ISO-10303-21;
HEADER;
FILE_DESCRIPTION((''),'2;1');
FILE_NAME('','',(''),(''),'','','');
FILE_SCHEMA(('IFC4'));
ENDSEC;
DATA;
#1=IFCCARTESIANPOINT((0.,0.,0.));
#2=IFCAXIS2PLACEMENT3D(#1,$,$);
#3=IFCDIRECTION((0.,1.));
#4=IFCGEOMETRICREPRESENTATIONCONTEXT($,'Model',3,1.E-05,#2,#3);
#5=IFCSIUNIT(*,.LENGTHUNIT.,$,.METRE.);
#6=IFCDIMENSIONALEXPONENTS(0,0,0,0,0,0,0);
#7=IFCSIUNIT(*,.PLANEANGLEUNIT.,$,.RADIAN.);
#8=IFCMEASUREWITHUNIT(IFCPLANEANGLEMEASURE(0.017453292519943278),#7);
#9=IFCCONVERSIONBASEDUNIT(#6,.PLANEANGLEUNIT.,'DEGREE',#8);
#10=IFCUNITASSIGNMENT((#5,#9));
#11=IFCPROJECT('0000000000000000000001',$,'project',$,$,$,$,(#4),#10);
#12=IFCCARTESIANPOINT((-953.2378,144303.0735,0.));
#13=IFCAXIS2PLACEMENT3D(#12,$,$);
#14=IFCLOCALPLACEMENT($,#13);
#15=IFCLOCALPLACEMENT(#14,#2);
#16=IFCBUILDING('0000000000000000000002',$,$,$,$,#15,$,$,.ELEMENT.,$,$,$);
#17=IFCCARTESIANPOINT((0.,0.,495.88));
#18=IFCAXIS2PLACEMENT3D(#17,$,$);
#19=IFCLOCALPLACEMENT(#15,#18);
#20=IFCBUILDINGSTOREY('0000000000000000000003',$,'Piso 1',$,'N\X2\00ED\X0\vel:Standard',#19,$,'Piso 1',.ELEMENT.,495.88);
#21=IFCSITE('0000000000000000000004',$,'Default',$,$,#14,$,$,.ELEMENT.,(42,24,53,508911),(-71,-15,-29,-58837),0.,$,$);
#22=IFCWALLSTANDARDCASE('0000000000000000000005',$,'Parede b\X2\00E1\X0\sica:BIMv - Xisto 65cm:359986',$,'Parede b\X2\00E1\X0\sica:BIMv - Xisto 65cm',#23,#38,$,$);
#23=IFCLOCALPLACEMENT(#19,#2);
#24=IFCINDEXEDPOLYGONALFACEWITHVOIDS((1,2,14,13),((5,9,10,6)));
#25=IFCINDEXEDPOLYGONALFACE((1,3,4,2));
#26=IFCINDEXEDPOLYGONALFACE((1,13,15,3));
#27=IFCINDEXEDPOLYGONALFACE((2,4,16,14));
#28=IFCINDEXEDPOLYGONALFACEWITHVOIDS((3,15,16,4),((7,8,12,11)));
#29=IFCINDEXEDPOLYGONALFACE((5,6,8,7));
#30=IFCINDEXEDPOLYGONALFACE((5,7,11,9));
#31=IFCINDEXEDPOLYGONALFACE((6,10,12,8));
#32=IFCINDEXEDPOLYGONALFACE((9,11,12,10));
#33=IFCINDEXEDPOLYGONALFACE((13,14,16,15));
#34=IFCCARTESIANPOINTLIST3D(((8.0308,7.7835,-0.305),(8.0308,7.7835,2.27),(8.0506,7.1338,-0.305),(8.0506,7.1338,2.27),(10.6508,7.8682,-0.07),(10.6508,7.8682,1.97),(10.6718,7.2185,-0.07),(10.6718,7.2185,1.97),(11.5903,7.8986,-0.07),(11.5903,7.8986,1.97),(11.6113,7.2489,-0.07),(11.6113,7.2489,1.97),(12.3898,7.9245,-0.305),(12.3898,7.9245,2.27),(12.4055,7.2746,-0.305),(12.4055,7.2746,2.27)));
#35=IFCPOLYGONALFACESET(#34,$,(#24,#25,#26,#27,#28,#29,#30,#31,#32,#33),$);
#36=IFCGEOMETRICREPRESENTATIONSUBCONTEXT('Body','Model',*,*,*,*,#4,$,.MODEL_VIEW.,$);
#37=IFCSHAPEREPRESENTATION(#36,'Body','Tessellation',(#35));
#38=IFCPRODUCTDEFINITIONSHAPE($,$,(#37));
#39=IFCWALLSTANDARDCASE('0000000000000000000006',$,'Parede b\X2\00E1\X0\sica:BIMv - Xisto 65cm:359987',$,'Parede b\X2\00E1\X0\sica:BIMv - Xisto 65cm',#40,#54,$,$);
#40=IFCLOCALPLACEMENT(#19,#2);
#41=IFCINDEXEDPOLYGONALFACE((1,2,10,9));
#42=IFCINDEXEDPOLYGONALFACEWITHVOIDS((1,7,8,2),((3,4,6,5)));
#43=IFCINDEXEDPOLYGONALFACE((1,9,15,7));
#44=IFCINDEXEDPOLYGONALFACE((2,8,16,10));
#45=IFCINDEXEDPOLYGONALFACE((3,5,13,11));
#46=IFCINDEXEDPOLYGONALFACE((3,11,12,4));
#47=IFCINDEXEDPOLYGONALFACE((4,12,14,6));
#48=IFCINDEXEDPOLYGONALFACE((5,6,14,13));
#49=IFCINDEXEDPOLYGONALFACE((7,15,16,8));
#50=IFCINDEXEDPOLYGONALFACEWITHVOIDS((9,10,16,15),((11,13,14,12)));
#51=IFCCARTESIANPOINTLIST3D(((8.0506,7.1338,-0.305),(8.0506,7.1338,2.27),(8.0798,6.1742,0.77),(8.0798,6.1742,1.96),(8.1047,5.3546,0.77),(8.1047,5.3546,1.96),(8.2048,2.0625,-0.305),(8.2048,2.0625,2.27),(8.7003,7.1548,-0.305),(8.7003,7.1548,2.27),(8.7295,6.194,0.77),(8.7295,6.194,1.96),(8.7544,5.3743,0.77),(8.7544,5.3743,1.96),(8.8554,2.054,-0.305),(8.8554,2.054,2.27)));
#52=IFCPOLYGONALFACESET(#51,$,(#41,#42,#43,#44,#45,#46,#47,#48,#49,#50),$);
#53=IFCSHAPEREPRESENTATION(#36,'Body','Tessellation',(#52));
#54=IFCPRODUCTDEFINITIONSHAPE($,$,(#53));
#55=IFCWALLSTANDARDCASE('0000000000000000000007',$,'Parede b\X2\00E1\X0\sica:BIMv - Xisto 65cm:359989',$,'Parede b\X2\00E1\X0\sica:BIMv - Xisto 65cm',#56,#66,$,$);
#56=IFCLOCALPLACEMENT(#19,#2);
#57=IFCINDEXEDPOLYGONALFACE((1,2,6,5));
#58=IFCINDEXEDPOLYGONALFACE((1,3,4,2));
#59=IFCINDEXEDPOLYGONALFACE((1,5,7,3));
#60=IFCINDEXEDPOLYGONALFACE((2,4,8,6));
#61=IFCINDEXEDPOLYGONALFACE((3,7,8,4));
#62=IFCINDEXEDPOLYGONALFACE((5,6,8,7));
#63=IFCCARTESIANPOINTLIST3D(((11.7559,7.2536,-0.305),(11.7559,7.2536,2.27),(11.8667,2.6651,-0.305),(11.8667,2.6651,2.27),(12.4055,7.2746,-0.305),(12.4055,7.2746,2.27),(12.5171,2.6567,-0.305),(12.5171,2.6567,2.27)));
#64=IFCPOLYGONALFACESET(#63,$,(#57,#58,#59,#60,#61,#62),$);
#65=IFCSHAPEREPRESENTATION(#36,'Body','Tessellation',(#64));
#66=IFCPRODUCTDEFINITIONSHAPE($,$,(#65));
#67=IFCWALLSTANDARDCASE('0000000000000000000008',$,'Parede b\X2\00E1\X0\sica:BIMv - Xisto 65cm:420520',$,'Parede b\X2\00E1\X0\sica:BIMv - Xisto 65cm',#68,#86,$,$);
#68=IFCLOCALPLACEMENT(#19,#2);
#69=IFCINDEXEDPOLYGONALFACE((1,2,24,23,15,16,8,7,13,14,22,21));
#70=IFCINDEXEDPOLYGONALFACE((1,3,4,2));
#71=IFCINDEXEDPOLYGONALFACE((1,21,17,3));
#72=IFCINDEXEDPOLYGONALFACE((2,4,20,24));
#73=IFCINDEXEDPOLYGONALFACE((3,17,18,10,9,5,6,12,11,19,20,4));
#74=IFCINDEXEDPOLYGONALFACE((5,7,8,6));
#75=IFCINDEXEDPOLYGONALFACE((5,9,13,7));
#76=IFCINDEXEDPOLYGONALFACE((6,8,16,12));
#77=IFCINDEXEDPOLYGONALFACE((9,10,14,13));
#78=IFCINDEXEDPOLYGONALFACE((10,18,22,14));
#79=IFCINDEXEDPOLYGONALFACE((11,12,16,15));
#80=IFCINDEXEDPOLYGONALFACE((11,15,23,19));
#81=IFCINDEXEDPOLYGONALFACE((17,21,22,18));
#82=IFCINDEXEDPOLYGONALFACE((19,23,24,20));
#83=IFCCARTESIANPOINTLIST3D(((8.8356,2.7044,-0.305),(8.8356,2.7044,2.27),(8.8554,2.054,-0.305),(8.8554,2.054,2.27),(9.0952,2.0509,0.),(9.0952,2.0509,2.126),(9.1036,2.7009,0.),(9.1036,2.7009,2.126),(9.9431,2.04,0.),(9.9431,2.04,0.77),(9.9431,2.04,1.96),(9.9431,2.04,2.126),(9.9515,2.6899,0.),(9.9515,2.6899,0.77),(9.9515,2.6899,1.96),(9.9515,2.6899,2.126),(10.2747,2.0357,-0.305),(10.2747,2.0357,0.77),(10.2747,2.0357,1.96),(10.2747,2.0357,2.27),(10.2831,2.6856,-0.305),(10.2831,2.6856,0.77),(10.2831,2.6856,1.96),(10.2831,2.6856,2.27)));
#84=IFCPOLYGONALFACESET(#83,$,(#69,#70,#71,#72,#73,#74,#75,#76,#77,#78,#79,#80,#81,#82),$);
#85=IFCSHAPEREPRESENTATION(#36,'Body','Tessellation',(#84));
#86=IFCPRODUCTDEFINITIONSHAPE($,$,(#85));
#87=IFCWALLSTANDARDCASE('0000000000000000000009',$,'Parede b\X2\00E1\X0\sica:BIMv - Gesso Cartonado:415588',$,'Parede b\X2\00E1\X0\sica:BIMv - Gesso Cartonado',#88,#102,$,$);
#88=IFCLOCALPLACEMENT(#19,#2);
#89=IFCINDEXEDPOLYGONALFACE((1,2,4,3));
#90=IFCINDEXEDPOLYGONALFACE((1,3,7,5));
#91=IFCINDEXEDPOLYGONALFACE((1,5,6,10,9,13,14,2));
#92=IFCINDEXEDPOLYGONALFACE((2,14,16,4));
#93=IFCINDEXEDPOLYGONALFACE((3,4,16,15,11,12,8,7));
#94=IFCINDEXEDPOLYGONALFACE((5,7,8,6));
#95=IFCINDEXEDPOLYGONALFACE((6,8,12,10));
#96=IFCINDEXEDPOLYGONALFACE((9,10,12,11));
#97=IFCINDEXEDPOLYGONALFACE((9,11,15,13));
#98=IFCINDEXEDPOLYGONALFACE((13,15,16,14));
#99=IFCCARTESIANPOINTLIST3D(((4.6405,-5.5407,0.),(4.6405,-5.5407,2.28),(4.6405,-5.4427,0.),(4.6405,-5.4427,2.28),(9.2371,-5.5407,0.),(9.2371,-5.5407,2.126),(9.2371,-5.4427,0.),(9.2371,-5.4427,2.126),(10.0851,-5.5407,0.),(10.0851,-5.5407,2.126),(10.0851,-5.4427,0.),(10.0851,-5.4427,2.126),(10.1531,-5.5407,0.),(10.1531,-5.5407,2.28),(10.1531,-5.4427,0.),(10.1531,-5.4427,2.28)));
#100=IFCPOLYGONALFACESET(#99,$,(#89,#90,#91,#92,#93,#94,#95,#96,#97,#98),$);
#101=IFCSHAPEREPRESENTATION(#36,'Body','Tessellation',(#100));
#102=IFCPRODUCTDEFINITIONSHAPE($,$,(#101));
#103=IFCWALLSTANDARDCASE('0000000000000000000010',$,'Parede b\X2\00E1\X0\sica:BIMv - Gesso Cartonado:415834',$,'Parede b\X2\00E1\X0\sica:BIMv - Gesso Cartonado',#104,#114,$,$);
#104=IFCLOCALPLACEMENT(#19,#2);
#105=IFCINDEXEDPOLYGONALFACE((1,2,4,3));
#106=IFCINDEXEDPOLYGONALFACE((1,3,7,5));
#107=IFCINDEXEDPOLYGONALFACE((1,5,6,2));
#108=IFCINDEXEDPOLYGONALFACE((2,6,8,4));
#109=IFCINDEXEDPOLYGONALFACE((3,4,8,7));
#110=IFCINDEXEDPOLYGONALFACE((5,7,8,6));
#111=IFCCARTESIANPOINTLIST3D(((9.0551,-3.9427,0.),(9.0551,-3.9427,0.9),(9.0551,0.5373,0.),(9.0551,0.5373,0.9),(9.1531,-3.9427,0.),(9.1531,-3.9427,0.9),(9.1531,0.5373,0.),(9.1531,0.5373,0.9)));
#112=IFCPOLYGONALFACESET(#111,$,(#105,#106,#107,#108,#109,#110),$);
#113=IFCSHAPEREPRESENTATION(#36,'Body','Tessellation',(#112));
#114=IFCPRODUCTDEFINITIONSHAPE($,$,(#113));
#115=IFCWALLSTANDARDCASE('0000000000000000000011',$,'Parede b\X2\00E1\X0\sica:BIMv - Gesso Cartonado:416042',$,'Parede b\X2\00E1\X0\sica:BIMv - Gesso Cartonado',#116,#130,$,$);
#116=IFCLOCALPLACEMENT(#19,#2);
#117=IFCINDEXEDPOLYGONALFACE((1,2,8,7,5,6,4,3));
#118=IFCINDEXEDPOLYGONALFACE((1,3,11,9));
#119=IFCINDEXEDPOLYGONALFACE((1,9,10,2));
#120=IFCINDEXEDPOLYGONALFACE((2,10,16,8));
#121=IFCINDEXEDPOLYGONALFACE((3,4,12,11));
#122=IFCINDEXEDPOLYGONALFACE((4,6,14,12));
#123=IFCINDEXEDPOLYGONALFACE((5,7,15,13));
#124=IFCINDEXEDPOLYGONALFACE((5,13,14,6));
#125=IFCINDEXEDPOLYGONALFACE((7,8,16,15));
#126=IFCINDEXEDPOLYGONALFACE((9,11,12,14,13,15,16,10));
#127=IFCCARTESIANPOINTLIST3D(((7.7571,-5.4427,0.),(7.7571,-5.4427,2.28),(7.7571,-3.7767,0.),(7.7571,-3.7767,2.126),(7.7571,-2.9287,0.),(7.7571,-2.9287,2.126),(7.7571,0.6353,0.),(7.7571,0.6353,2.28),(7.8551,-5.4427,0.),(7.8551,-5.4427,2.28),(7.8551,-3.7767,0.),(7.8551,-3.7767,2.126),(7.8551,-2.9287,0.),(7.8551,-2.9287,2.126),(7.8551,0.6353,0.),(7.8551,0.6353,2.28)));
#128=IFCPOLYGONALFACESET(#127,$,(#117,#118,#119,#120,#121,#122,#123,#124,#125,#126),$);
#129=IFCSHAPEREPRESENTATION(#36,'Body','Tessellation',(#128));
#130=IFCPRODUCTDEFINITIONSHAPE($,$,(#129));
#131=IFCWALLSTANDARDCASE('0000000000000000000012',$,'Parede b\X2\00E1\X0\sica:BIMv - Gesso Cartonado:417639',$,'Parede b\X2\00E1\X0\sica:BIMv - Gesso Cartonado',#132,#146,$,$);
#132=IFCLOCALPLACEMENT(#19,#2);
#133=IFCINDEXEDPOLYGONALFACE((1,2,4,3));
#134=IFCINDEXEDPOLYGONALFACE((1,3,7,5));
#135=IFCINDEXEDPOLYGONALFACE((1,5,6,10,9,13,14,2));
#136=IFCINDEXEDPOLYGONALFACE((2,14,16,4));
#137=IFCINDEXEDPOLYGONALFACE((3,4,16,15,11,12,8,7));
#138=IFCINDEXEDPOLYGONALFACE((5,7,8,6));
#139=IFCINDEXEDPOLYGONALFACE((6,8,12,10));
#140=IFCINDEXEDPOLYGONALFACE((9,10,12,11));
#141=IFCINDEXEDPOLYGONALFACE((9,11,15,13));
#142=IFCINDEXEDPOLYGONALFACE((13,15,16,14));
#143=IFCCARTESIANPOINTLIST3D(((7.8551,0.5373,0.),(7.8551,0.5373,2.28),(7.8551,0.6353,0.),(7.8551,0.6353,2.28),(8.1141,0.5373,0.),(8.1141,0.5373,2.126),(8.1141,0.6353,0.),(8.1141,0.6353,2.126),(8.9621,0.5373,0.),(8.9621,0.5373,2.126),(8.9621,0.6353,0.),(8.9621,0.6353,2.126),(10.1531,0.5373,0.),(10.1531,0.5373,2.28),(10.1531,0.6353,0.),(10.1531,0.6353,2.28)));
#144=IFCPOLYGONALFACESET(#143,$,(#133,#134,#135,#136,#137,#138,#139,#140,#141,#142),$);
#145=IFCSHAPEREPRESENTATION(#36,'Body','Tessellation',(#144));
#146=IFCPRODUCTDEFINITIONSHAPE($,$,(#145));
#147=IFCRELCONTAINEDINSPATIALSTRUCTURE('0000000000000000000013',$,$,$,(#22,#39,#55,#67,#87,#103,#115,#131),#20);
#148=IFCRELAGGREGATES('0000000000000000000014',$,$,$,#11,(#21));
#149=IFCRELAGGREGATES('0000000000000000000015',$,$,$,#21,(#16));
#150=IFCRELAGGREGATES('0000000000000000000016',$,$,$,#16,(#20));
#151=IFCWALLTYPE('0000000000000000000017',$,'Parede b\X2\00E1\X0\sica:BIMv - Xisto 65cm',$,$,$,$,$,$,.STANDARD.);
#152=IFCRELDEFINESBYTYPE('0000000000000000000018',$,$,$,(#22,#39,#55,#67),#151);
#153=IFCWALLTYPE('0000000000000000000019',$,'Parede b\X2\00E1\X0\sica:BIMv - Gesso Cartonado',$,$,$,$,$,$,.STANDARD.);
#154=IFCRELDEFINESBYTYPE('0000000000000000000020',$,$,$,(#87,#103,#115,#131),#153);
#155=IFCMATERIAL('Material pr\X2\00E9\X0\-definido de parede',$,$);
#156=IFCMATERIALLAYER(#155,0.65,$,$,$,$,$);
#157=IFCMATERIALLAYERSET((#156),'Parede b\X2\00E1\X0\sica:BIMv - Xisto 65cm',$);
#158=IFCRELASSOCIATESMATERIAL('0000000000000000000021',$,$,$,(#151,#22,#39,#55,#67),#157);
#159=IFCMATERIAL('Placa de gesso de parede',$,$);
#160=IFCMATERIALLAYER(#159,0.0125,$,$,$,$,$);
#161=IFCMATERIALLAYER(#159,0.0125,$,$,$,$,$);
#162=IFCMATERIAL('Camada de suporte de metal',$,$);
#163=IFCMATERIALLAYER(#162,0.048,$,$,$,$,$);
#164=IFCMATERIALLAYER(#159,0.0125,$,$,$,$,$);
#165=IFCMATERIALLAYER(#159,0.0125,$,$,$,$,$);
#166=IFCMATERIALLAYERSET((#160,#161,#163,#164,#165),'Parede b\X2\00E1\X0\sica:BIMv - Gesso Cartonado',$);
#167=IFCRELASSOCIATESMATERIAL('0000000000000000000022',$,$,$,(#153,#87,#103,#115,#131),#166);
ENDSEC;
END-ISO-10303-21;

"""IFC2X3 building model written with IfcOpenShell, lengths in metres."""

from ifc_helpers import new_model, entity, si_unit, converted_unit, direction, frame, frame_2d, origin, origin_2d_with_axis, place, context, subcontext, project, spatial, polyline, rectangle, outline, extrude, clip, bounded_halfspace, material, layer, layer_set, layer_usage, type_object, element, save


model = new_model("IFC2X3")

# Units and contexts
model_context = context("Model", 3, precision=1e-05, world=origin(), true_north=direction((0.0, 1.0)))
body_context = subcontext(model_context, "Body", "Model", "MODEL_VIEW")
ifc_project = project(units=[si_unit("LENGTHUNIT", "METRE"), converted_unit("PLANEANGLEUNIT", "DEGREE", entity("IfcPlaneAngleMeasure", 0.017453292519943278), si_unit("PLANEANGLEUNIT", "RADIAN"), dimensions=[0, 0, 0, 0, 0, 0, 0])], contexts=[model_context])

# Site, building, storey
site_placement = place(None, frame((-953.2378, 144303.0735, 0.0)))
site = spatial("IfcSite", under=ifc_project, at=site_placement, Name="Default", CompositionType="ELEMENT", RefLatitude=(42, 24, 53, 508911), RefLongitude=(-71, -15, -29, -58837), RefElevation=0.0)
building_placement = place(site_placement, origin())
building = spatial("IfcBuilding", under=site, at=building_placement, CompositionType="ELEMENT")
storey_placement = place(building_placement, frame((0.0, 0.0, 495.88)))
storey = spatial("IfcBuildingStorey", under=building, at=storey_placement, Name="Piso 1", ObjectType="Nível:Standard", LongName="Piso 1", CompositionType="ELEMENT", Elevation=495.88)

# Walls, openings
ifc_material_1 = material(Name="Material pré-definido de parede")
ifc_layer_1 = layer(ifc_material_1, 0.65)
ifc_layer_set_1 = layer_set([ifc_layer_1], Name="Parede básica:BIMv - Xisto 65cm")
ifc_layer_usage_1 = layer_usage(ifc_layer_set_1, "AXIS2", "NEGATIVE", 0.325)
wall_type_1 = type_object("IfcWallType", Name="Parede básica:BIMv - Xisto 65cm", PredefinedType="STANDARD", material=ifc_layer_set_1)
wall_1_placement = place(storey_placement, frame((8.0401, 7.4586, -0.305), z_axis=(0.0, 0.0, 1.0), x_axis=(0.999477, 0.03233, 0.0)))
wall_1 = element("IfcWallStandardCase", 1, at=wall_1_placement, inside=storey, type_object=wall_type_1, material=ifc_layer_usage_1, Name="Parede básica:BIMv - Xisto 65cm:359986", ObjectType="Parede básica:BIMv - Xisto 65cm", context=body_context, shape_type="SweptSolid", body=[
    extrude(outline(polyline([(4.3572, -0.325), (4.3625, 0.325), (0.0013, 0.325), (0.0, -0.325), (0.65, -0.325), (3.7072, -0.325), (4.3572, -0.325)])), origin(), (0.0, 0.0, 1.0), 2.575),
])
opening_1_placement = place(wall_1_placement, frame((-8.277, -7.1948, 0.305), z_axis=(0.0, 0.0, 1.0), x_axis=(0.999477, -0.03233, 0.0)))
element("IfcOpeningElement", 2, at=opening_1_placement, cuts=wall_1, ObjectType="Opening", context=body_context, shape_type="SweptSolid", body=[
    extrude(rectangle(XDim=2.04, YDim=0.94, at=frame_2d((0.0, 0.0), x_axis=(0.0, 1.0))), frame((11.1908, 5.7105, 0.95), z_axis=(-0.03233, 0.999477, 0.0), x_axis=(-0.999477, -0.03233, 0.0)), (0.0, 0.0, 1.0), 3.048),
])
ifc_layer_usage_2 = layer_usage(ifc_layer_set_1, "AXIS2", "NEGATIVE", 0.325)
wall_2_placement = place(storey_placement, frame((8.5305, 2.0442, -0.305), z_axis=(0.0, 0.0, 1.0), x_axis=(-0.030399, 0.999538, 0.0)))
wall_2 = element("IfcWallStandardCase", 3, at=wall_2_placement, inside=storey, type_object=wall_type_1, material=ifc_layer_usage_2, Name="Parede básica:BIMv - Xisto 65cm:359987", ObjectType="Parede básica:BIMv - Xisto 65cm", context=body_context, shape_type="SweptSolid", body=[
    extrude(outline(polyline([(5.1031, -0.325), (5.1018, 0.325), (0.0282, 0.325), (0.0, -0.325), (5.1031, -0.325)])), origin(), (0.0, 0.0, 1.0), 2.575),
])
opening_2_placement = place(wall_2_placement, frame((-1.7839, 8.5887, 0.305), z_axis=(0.0, 0.0, 1.0), x_axis=(-0.030399, -0.999538, 0.0)))
element("IfcOpeningElement", 4, at=opening_2_placement, cuts=wall_2, ObjectType="Opening", context=body_context, shape_type="SweptSolid", body=[
    extrude(rectangle(XDim=1.19, YDim=0.82, at=origin_2d_with_axis()), frame((10.2652, 5.8305, 1.365), z_axis=(-0.999538, -0.030399, 0.0), x_axis=(0.0, 0.0, 1.0)), (0.0, 0.0, 1.0), 3.048),
])

# Wall
ifc_layer_usage_3 = layer_usage(ifc_layer_set_1, "AXIS2", "NEGATIVE", 0.325)
wall_3_placement = place(storey_placement, frame((12.0806, 7.2668, -0.305), z_axis=(0.0, 0.0, 1.0), x_axis=(0.024156, -0.999708, 0.0)))
element("IfcWallStandardCase", 5, at=wall_3_placement, inside=storey, type_object=wall_type_1, material=ifc_layer_usage_3, Name="Parede básica:BIMv - Xisto 65cm:359989", ObjectType="Parede básica:BIMv - Xisto 65cm", context=body_context, shape_type="SweptSolid", body=[
    extrude(outline(polyline([(4.5951, -0.325), (4.6193, 0.325), (0.0, 0.325), (0.0053, -0.325), (4.5951, -0.325)])), origin(), (0.0, 0.0, 1.0), 2.575),
])

# Wall, openings
ifc_layer_usage_4 = layer_usage(ifc_layer_set_1, "AXIS2", "NEGATIVE", 0.325)
wall_4_placement = place(storey_placement, frame((10.2789, 2.3607, -0.305), z_axis=(0.0, 0.0, 1.0), x_axis=(-0.999916, 0.012938, 0.0)))
wall_4 = element("IfcWallStandardCase", 6, at=wall_4_placement, inside=storey, type_object=wall_type_1, material=ifc_layer_usage_4, Name="Parede básica:BIMv - Xisto 65cm:420520", ObjectType="Parede básica:BIMv - Xisto 65cm", context=body_context, shape_type="SweptSolid", body=[
    extrude(outline(polyline([(1.4476, -0.325), (1.4194, 0.325), (0.0, 0.325), (0.0, -0.325), (1.4476, -0.325)])), origin(), (0.0, 0.0, 1.0), 2.575),
])
opening_3_placement = place(wall_4_placement, frame((10.2475, 2.4934, 0.305), z_axis=(0.0, 0.0, 1.0), x_axis=(-0.999916, -0.012938, 0.0)))
element("IfcOpeningElement", 7, at=opening_3_placement, cuts=wall_4, ObjectType="Opening", context=body_context, shape_type="SweptSolid", body=[
    extrude(rectangle(XDim=1.19, YDim=0.9, at=frame_2d((0.0, 0.0), x_axis=(0.0, 1.0))), frame((9.8444, 3.5654, 1.365), z_axis=(-0.012938, -0.999916, 0.0), x_axis=(0.999916, -0.012938, 0.0)), (0.0, 0.0, 1.0), 3.048),
])
opening_4_placement = place(wall_4_placement, frame((1.1796, 0.325, 0.305)))
element("IfcOpeningElement", 8, at=opening_4_placement, cuts=wall_4, ObjectType="Opening", context=body_context, shape_type="SweptSolid", body=[
    extrude(rectangle(XDim=2.126, YDim=0.848, at=frame_2d((1.063, 0.424), x_axis=(1.0, 0.0))), frame((0.0, 0.0, 0.0), z_axis=(0.0, -1.0, 0.0), x_axis=(0.0, 0.0, 1.0)), (0.0, 0.0, 1.0), 0.65),
])

# Wall, opening
ifc_material_2 = material(Name="Placa de gesso de parede")
ifc_layer_2 = layer(ifc_material_2, 0.0125)
ifc_layer_3 = layer(ifc_material_2, 0.0125)
ifc_material_3 = material(Name="Camada de suporte de metal")
ifc_layer_4 = layer(ifc_material_3, 0.048)
ifc_layer_5 = layer(ifc_material_2, 0.0125)
ifc_layer_6 = layer(ifc_material_2, 0.0125)
ifc_layer_set_2 = layer_set([ifc_layer_2, ifc_layer_3, ifc_layer_4, ifc_layer_5, ifc_layer_6], Name="Parede básica:BIMv - Gesso Cartonado")
ifc_layer_usage_5 = layer_usage(ifc_layer_set_2, "AXIS2", "NEGATIVE", 0.049)
wall_type_2 = type_object("IfcWallType", Name="Parede básica:BIMv - Gesso Cartonado", PredefinedType="STANDARD", material=ifc_layer_set_2)
wall_5_placement = place(storey_placement, frame((10.1531, -5.4917, 0.0), z_axis=(0.0, 0.0, 1.0), x_axis=(-1.0, 0.0, 0.0)))
wall_5 = element("IfcWallStandardCase", 9, at=wall_5_placement, inside=storey, type_object=wall_type_2, material=ifc_layer_usage_5, Name="Parede básica:BIMv - Gesso Cartonado:415588", ObjectType="Parede básica:BIMv - Gesso Cartonado", context=body_context, shape_type="Clipping", body=[
    clip(extrude(rectangle(XDim=5.5127, YDim=0.098, at=frame_2d((2.7563, 0.0), x_axis=(1.0, 0.0))), origin(), (0.0, 0.0, 1.0), 2.28), bounded_halfspace(frame((0.0, -0.049, 2.28), z_axis=(0.0, 0.0, -1.0), x_axis=(-0.030399, 0.999538, 0.0)), True, frame((0.0, -0.049, 2.28)), polyline([(0.0, 0.0), (2.298, 0.0), (2.396, 0.0), (3.9053, 0.0), (4.0033, 0.0), (5.5127, 0.0), (5.5127, 0.098), (0.0, 0.098), (0.0, 0.0)]))),
])
opening_5_placement = place(wall_5_placement, frame((0.068, -0.049, 0.0)))
element("IfcOpeningElement", 10, at=opening_5_placement, cuts=wall_5, ObjectType="Opening", context=body_context, shape_type="SweptSolid", body=[
    extrude(rectangle(XDim=2.126, YDim=0.848, at=frame_2d((1.063, 0.424), x_axis=(1.0, 0.0))), frame((0.0, 0.0, 0.0), z_axis=(0.0, 1.0, 0.0), x_axis=(0.0, 0.0, 1.0)), (0.0, 0.0, 1.0), 0.098),
])

# Wall
ifc_layer_usage_6 = layer_usage(ifc_layer_set_2, "AXIS2", "NEGATIVE", 0.049)
wall_6_placement = place(storey_placement, frame((9.1041, -3.9427, 0.0), z_axis=(0.0, 0.0, 1.0), x_axis=(0.0, 1.0, 0.0)))
element("IfcWallStandardCase", 11, at=wall_6_placement, inside=storey, type_object=wall_type_2, material=ifc_layer_usage_6, Name="Parede básica:BIMv - Gesso Cartonado:415834", ObjectType="Parede básica:BIMv - Gesso Cartonado", context=body_context, shape_type="SweptSolid", body=[
    extrude(rectangle(XDim=4.48, YDim=0.098, at=frame_2d((2.24, 0.0), x_axis=(-1.0, 0.0))), origin(), (0.0, 0.0, 1.0), 0.9),
])

# Walls, openings
ifc_layer_usage_7 = layer_usage(ifc_layer_set_2, "AXIS2", "NEGATIVE", 0.049)
wall_7_placement = place(storey_placement, frame((7.8061, -5.4427, 0.0), z_axis=(0.0, 0.0, 1.0), x_axis=(0.0, 1.0, 0.0)))
wall_7 = element("IfcWallStandardCase", 12, at=wall_7_placement, inside=storey, type_object=wall_type_2, material=ifc_layer_usage_7, Name="Parede básica:BIMv - Gesso Cartonado:416042", ObjectType="Parede básica:BIMv - Gesso Cartonado", context=body_context, shape_type="Clipping", body=[
    clip(extrude(rectangle(XDim=6.078, YDim=0.098, at=frame_2d((3.039, 0.0), x_axis=(1.0, 0.0))), origin(), (0.0, 0.0, 1.0), 2.28), bounded_halfspace(frame((0.0, -0.049, 2.28), z_axis=(0.0, 0.0, -1.0), x_axis=(-0.999538, -0.030399, 0.0)), True, frame((0.0, -0.049, 2.28)), polyline([(0.0, 0.0), (5.98, 0.0), (6.078, 0.0), (6.078, 0.098), (5.478, 0.098), (5.38, 0.098), (1.598, 0.098), (1.5, 0.098), (0.0, 0.098), (0.0, 0.0)]))),
])
opening_6_placement = place(wall_7_placement, frame((1.666, -0.049, 0.0)))
element("IfcOpeningElement", 13, at=opening_6_placement, cuts=wall_7, ObjectType="Opening", context=body_context, shape_type="SweptSolid", body=[
    extrude(rectangle(XDim=2.126, YDim=0.848, at=frame_2d((1.063, 0.424), x_axis=(1.0, 0.0))), frame((0.0, 0.0, 0.0), z_axis=(0.0, 1.0, 0.0), x_axis=(0.0, 0.0, 1.0)), (0.0, 0.0, 1.0), 0.098),
])
ifc_layer_usage_8 = layer_usage(ifc_layer_set_2, "AXIS2", "NEGATIVE", 0.049)
wall_8_placement = place(storey_placement, frame((7.8551, 0.5863, 0.0)))
wall_8 = element("IfcWallStandardCase", 14, at=wall_8_placement, inside=storey, type_object=wall_type_2, material=ifc_layer_usage_8, Name="Parede básica:BIMv - Gesso Cartonado:417639", ObjectType="Parede básica:BIMv - Gesso Cartonado", context=body_context, shape_type="Clipping", body=[
    clip(extrude(rectangle(XDim=2.298, YDim=0.098, at=frame_2d((1.149, 0.0), x_axis=(-1.0, 0.0))), origin(), (0.0, 0.0, 1.0), 2.28), bounded_halfspace(frame((0.0, -0.049, 2.28), z_axis=(0.0, 0.0, -1.0), x_axis=(0.030399, -0.999538, 0.0)), True, frame((0.0, -0.049, 2.28)), polyline([(0.0, 0.0), (2.298, 0.0), (2.298, 0.098), (0.0, 0.098), (0.0, 0.0)]))),
])
opening_7_placement = place(wall_8_placement, frame((0.259, -0.049, 0.0)))
element("IfcOpeningElement", 15, at=opening_7_placement, cuts=wall_8, ObjectType="Opening", context=body_context, shape_type="SweptSolid", body=[
    extrude(rectangle(XDim=2.126, YDim=0.848, at=frame_2d((1.063, 0.424), x_axis=(1.0, 0.0))), frame((0.0, 0.0, 0.0), z_axis=(0.0, 1.0, 0.0), x_axis=(0.0, 0.0, 1.0)), (0.0, 0.0, 1.0), 0.098),
])

save(model, "model.ifc")
